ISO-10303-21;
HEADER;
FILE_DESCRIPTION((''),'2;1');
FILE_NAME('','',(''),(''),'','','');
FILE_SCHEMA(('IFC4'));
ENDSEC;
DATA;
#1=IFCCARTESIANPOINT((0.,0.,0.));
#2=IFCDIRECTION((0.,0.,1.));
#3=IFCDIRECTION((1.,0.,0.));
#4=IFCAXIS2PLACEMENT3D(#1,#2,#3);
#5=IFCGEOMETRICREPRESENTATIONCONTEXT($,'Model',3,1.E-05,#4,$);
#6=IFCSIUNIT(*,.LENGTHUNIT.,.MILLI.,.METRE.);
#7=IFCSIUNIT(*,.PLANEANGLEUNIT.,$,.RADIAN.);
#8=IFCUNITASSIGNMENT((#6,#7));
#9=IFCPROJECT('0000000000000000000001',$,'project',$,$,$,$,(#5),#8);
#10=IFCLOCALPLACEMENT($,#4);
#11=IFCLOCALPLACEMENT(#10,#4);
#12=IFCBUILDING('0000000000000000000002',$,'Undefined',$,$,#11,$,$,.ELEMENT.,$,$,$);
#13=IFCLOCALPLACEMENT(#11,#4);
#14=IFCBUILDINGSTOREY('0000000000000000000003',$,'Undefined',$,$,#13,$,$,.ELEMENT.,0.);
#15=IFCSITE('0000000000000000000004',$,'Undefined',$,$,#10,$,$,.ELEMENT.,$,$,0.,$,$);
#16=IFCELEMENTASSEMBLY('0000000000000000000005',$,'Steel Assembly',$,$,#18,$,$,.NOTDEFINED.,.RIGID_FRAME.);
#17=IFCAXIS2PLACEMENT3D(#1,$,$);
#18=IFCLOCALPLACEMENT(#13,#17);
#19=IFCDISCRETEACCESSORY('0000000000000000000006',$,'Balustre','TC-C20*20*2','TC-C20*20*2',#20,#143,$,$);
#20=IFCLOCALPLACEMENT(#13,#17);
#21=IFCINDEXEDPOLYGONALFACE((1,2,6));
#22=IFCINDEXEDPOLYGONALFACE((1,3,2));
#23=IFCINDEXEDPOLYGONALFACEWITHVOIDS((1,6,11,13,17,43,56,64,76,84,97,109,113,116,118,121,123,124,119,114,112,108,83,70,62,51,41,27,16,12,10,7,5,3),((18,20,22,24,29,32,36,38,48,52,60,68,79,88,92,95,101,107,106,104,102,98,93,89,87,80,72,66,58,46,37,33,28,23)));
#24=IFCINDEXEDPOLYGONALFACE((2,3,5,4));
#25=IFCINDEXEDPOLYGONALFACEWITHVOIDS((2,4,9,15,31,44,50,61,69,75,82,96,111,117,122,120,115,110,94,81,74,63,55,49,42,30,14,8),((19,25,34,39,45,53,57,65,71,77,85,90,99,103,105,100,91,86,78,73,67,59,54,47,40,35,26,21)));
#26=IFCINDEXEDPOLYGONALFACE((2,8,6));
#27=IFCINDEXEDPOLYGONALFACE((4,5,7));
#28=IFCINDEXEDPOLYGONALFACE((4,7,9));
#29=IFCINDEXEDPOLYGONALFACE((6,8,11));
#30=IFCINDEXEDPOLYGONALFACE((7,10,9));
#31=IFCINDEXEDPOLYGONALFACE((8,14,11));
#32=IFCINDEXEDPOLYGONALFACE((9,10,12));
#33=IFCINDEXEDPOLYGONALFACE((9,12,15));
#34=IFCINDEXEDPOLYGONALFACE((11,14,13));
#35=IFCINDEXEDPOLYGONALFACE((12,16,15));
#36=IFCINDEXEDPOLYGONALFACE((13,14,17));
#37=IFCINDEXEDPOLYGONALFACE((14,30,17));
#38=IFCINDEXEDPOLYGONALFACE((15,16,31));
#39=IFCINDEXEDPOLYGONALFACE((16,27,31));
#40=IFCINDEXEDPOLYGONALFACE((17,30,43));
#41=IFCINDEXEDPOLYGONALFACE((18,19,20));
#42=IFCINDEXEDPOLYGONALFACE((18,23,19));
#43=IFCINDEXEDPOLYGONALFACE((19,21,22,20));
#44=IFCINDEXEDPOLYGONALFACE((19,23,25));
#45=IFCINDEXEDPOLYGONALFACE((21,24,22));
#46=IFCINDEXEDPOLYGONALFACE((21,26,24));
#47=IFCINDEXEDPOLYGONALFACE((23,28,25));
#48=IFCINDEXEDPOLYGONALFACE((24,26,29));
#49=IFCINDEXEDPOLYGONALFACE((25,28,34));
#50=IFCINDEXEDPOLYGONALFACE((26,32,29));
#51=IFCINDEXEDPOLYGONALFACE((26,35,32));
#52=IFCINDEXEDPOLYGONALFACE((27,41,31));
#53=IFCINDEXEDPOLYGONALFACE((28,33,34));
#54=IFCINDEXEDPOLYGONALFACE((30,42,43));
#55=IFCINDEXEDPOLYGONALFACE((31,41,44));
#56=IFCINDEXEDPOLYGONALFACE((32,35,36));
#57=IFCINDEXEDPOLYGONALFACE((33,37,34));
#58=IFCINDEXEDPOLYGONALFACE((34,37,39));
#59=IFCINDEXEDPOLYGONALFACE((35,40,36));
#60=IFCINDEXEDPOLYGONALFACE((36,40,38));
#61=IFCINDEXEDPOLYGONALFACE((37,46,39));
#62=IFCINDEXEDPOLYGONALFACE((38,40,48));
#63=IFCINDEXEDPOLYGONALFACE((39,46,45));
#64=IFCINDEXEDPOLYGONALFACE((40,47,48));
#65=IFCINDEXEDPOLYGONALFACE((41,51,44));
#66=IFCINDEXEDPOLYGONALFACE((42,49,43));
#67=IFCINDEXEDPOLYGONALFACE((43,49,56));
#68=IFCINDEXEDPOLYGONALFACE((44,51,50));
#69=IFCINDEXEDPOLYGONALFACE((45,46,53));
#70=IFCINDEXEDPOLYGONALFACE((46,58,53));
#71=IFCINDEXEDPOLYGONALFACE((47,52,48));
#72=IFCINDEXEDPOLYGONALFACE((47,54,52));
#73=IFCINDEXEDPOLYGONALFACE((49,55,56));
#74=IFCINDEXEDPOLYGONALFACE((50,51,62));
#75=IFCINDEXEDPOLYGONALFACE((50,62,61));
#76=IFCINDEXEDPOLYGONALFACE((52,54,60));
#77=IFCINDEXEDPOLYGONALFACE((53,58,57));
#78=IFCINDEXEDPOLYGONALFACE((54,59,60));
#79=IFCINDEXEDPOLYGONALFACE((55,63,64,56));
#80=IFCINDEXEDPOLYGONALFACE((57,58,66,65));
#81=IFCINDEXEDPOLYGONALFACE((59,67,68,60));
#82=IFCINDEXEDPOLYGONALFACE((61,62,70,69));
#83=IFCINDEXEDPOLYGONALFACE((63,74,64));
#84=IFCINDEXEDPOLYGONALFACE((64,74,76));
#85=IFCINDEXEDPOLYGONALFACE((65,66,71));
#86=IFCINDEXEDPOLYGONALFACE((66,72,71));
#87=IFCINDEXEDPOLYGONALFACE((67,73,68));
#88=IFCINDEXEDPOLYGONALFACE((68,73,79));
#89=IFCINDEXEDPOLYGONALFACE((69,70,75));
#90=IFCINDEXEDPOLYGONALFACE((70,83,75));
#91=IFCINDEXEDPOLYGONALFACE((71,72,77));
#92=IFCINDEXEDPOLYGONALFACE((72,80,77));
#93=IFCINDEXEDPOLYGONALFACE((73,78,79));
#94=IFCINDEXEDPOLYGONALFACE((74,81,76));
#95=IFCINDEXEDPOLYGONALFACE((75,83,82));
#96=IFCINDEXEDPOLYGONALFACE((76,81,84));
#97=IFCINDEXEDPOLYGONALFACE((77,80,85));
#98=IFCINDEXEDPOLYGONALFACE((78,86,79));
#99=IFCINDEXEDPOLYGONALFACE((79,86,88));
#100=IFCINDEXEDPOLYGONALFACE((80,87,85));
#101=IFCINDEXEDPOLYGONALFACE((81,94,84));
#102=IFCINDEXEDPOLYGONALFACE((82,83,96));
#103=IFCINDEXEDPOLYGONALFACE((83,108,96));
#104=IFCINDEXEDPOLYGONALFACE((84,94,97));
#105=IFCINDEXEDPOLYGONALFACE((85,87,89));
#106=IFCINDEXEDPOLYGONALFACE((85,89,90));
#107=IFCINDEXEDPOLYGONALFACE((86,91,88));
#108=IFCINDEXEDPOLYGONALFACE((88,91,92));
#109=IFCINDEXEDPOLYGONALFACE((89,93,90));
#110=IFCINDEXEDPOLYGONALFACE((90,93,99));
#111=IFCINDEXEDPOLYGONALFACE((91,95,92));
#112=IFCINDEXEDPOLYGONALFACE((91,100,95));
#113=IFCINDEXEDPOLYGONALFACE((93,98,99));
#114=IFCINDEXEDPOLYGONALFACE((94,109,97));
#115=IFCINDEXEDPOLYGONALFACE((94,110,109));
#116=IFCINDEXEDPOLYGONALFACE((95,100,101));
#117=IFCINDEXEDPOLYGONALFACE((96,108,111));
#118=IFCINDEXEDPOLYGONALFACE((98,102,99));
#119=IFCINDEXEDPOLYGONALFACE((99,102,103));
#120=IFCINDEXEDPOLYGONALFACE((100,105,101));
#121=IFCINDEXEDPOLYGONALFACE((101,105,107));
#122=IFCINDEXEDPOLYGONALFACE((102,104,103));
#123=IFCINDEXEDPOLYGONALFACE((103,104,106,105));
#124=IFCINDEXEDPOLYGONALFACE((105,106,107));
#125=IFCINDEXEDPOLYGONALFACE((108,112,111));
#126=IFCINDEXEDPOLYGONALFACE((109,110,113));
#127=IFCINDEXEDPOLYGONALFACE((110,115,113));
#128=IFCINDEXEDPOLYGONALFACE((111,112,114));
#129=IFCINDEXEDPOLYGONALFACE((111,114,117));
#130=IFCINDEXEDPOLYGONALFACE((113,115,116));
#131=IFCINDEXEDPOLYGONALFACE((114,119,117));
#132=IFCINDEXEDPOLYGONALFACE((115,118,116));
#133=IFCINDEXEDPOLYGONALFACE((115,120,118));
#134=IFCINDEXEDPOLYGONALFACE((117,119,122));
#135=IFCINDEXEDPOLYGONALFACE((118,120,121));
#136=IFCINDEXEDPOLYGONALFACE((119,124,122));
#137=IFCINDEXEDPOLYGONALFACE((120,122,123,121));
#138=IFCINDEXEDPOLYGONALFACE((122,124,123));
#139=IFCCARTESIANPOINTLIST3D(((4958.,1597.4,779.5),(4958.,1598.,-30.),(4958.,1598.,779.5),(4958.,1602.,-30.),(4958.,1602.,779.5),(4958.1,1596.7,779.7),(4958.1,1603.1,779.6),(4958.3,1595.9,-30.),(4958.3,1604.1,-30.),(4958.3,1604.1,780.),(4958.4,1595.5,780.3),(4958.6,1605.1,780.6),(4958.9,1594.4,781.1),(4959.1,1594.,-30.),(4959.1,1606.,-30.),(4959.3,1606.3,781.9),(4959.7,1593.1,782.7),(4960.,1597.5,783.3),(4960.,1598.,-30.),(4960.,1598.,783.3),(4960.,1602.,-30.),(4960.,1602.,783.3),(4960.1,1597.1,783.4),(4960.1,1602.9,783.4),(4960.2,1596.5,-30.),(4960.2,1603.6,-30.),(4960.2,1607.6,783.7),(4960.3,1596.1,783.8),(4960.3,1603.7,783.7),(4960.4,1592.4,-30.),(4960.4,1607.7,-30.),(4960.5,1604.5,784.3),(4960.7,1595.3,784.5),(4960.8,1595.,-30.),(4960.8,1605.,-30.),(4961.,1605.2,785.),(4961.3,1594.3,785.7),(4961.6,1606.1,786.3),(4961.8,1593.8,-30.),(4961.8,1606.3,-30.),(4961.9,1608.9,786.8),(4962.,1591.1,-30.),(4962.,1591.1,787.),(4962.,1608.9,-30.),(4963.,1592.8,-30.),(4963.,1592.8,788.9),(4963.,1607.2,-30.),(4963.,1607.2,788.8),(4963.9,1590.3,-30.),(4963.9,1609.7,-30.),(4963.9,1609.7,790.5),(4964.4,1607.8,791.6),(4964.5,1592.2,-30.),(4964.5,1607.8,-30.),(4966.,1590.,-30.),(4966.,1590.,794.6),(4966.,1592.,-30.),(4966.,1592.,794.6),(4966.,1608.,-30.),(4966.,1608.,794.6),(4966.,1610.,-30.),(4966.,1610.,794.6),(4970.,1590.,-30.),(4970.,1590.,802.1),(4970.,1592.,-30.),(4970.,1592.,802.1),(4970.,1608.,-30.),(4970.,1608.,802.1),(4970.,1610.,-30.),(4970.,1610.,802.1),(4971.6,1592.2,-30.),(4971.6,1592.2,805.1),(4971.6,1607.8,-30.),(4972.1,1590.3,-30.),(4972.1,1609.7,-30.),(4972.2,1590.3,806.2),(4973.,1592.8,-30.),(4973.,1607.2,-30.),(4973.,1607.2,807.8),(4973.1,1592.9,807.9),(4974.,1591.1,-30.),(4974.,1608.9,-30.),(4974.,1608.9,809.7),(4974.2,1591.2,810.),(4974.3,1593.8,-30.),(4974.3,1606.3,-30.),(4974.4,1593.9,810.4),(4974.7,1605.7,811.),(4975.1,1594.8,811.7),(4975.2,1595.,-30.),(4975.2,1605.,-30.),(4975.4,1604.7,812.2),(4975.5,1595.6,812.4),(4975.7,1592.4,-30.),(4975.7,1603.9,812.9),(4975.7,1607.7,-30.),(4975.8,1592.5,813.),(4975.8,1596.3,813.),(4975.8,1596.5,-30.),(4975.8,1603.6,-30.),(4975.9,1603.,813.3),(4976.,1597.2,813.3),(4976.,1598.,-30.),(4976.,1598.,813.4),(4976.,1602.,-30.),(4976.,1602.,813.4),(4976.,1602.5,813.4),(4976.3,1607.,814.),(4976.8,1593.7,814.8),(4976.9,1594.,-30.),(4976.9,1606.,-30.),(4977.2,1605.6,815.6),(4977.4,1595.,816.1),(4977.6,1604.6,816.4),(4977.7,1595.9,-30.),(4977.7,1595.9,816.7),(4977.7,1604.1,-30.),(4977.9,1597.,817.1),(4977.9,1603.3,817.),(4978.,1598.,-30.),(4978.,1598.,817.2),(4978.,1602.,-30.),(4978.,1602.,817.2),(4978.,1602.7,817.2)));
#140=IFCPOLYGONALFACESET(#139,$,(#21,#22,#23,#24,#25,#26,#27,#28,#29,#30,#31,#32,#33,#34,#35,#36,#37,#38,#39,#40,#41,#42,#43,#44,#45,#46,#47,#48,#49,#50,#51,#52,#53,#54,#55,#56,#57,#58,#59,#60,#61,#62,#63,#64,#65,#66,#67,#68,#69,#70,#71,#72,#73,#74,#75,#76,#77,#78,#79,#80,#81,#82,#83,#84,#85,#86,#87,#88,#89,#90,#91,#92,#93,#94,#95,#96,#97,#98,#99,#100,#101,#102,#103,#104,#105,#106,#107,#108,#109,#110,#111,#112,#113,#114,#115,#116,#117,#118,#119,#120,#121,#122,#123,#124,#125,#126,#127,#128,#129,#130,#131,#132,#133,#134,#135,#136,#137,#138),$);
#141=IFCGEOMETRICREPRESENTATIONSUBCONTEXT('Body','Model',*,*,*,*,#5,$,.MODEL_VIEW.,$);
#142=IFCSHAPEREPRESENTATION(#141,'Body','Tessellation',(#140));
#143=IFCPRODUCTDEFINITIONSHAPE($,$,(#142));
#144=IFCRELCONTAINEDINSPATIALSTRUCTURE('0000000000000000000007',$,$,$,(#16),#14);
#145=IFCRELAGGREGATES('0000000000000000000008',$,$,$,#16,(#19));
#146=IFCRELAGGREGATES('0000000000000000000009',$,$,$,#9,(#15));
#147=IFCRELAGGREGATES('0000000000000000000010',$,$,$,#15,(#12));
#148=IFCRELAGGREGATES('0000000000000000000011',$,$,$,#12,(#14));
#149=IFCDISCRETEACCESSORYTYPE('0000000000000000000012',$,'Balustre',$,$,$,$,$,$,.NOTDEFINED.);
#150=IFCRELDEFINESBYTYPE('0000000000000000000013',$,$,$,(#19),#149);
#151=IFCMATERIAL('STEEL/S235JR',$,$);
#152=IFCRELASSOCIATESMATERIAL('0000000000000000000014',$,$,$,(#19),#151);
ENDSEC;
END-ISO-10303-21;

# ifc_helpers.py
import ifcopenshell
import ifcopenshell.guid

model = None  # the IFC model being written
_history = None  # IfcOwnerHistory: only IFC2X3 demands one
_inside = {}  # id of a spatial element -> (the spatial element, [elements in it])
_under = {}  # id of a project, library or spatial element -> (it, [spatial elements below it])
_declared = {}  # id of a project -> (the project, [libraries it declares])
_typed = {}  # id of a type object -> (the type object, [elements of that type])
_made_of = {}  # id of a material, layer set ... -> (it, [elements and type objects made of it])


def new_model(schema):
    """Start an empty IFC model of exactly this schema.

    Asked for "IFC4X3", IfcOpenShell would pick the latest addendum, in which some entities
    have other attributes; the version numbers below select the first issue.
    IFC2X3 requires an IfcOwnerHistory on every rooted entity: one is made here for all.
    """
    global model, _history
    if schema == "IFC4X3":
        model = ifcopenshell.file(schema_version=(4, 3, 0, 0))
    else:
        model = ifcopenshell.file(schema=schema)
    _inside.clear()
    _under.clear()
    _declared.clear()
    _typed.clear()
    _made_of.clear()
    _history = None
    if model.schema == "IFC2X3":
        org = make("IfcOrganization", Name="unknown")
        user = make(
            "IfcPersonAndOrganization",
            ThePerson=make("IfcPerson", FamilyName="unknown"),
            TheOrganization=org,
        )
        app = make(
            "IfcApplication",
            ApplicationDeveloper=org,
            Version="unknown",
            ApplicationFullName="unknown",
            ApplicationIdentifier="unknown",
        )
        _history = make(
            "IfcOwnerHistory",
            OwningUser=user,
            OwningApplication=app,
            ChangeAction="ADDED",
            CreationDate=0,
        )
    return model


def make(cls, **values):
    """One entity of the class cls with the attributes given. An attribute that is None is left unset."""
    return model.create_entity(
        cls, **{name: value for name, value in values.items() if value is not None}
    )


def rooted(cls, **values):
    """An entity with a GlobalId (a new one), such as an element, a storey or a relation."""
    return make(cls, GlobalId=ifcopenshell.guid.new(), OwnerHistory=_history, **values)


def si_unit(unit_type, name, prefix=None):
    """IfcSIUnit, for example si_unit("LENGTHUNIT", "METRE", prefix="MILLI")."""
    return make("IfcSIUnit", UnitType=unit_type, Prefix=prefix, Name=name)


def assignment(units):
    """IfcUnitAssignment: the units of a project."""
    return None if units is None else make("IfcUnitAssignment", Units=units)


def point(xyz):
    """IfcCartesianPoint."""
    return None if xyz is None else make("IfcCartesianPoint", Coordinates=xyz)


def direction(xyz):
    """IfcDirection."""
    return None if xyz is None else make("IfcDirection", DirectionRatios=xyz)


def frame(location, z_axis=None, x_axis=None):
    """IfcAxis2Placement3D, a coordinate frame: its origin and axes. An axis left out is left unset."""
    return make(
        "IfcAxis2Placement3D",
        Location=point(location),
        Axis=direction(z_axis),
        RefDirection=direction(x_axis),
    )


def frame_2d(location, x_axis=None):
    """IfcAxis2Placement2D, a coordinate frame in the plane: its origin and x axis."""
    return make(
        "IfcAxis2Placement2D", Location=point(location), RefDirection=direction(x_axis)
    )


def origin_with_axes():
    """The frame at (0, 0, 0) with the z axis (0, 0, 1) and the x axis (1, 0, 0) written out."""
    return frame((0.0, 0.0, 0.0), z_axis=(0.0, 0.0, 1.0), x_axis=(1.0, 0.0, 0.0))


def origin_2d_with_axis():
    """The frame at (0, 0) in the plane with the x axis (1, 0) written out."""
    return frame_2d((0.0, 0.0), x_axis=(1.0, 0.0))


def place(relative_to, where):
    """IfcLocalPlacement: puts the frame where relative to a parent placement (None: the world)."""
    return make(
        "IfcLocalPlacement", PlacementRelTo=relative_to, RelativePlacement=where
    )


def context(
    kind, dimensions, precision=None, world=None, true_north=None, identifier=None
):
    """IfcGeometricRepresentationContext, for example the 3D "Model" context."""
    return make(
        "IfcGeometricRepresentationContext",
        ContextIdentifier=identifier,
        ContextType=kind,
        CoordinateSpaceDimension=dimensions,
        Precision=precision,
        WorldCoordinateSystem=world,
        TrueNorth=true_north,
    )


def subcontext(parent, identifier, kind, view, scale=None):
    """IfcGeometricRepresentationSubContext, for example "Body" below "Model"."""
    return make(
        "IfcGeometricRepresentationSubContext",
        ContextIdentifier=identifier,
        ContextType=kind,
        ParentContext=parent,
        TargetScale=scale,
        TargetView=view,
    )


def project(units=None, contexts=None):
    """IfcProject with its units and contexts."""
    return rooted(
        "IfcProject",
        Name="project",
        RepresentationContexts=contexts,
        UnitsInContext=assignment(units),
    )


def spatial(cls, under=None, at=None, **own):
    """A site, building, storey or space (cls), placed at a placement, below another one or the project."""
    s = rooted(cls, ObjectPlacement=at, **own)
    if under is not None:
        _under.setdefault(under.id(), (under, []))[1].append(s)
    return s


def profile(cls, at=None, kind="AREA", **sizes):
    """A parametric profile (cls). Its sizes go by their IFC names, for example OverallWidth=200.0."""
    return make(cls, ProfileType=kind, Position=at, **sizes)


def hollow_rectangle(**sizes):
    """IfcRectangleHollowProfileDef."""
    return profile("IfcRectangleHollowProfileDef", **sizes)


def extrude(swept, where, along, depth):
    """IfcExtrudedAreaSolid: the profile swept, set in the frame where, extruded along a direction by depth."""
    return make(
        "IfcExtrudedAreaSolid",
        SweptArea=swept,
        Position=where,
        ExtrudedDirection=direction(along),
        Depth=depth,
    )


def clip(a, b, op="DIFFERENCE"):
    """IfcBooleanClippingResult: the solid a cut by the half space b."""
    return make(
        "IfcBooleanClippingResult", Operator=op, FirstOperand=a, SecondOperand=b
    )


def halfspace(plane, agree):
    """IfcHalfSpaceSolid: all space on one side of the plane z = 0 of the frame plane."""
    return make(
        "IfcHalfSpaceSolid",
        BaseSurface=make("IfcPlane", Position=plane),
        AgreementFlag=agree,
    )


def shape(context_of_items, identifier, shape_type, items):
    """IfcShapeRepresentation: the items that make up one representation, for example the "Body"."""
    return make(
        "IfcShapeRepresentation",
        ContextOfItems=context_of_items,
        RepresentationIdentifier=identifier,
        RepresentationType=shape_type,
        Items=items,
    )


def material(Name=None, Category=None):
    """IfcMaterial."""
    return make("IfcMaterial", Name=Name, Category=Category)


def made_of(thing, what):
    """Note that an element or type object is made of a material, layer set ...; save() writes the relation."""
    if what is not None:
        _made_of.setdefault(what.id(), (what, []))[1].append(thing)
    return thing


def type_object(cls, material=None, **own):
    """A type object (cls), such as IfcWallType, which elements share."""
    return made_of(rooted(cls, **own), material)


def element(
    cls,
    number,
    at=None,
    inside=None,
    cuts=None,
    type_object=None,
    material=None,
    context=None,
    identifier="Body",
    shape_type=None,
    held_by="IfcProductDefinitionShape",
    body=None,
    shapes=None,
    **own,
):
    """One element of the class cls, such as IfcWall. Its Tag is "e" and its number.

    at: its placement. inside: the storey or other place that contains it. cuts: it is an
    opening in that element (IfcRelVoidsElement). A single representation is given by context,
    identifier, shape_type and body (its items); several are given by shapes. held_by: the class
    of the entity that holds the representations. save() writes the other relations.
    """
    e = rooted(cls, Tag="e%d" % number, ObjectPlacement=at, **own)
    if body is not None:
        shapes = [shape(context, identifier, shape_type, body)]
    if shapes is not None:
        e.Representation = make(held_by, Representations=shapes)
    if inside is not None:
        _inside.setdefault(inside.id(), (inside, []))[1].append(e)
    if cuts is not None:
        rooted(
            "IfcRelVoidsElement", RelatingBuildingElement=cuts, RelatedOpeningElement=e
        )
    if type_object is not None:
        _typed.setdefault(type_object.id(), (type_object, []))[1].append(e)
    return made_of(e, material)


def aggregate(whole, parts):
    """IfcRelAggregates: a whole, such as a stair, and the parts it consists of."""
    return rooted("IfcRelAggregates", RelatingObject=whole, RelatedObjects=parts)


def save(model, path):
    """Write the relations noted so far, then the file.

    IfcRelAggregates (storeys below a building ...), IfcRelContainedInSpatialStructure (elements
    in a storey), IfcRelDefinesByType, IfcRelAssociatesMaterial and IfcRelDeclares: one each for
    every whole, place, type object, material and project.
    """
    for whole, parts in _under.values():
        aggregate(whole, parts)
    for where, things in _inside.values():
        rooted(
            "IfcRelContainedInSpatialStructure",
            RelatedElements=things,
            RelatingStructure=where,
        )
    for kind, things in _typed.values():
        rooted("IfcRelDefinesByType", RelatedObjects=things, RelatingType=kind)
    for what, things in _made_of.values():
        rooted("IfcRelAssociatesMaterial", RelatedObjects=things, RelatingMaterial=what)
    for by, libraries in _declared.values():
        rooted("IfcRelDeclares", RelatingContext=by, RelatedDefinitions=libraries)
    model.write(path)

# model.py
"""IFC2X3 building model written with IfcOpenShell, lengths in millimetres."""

from ifc_helpers import new_model, si_unit, frame, origin_with_axes, origin_2d_with_axis, place, context, subcontext, project, spatial, hollow_rectangle, extrude, clip, halfspace, material, type_object, element, aggregate, save


model = new_model("IFC2X3")

# Units and contexts
model_context = context("Model", 3, precision=1e-05, world=origin_with_axes())
body_context = subcontext(model_context, "Body", "Model", "MODEL_VIEW")
ifc_project = project(units=[si_unit("LENGTHUNIT", "METRE", prefix="MILLI"), si_unit("PLANEANGLEUNIT", "RADIAN")], contexts=[model_context])

# Site, building, storey
site_placement = place(None, origin_with_axes())
site = spatial("IfcSite", under=ifc_project, at=site_placement, Name="Undefined", CompositionType="ELEMENT", RefElevation=0.0)
building_placement = place(site_placement, origin_with_axes())
building = spatial("IfcBuilding", under=site, at=building_placement, Name="Undefined", CompositionType="ELEMENT")
storey_placement = place(building_placement, origin_with_axes())
storey = spatial("IfcBuildingStorey", under=building, at=storey_placement, Name="Undefined", CompositionType="ELEMENT", Elevation=0.0)

# Shared definitions
ifc_material = material(Name="STEEL/S235JR")

# Element assembly, discrete accessory
assembly_1_placement = place(storey_placement, origin_with_axes())
assembly_1 = element("IfcElementAssembly", 1, at=assembly_1_placement, inside=storey, Name="Steel Assembly", AssemblyPlace="NOTDEFINED", PredefinedType="RIGID_FRAME")
discrete_accessory_type_1 = type_object("IfcDiscreteAccessoryType", Name="Balustre")
discrete_accessory_1_placement = place(assembly_1_placement, frame((4968.0, 1600.0, -30.0), z_axis=(0.0, 0.0, 1.0), x_axis=(1.0, 0.0, 0.0)))
discrete_accessory_1 = element("IfcDiscreteAccessory", 2, at=discrete_accessory_1_placement, type_object=discrete_accessory_type_1, material=ifc_material, Name="Balustre", Description="TC-C20*20*2", ObjectType="TC-C20*20*2", context=body_context, shape_type="Clipping", body=[
    clip(extrude(hollow_rectangle(XDim=20.0, YDim=20.0, WallThickness=2.0, InnerFilletRadius=6.0, OuterFilletRadius=8.0, at=origin_2d_with_axis()), frame((0.0, 0.0, 847.4), z_axis=(0.0, 0.0, -1.0), x_axis=(-1.0, 0.0, 0.0)), (0.0, 0.0, 1.0), 847.4), halfspace(frame((14.2, 0.0, 855.2), z_axis=(0.883506, 0.000005, -0.46842), x_axis=(-0.000005, 1.0, 0.0)), True)),
])

aggregate(assembly_1, [discrete_accessory_1])

save(model, "model.ifc")
